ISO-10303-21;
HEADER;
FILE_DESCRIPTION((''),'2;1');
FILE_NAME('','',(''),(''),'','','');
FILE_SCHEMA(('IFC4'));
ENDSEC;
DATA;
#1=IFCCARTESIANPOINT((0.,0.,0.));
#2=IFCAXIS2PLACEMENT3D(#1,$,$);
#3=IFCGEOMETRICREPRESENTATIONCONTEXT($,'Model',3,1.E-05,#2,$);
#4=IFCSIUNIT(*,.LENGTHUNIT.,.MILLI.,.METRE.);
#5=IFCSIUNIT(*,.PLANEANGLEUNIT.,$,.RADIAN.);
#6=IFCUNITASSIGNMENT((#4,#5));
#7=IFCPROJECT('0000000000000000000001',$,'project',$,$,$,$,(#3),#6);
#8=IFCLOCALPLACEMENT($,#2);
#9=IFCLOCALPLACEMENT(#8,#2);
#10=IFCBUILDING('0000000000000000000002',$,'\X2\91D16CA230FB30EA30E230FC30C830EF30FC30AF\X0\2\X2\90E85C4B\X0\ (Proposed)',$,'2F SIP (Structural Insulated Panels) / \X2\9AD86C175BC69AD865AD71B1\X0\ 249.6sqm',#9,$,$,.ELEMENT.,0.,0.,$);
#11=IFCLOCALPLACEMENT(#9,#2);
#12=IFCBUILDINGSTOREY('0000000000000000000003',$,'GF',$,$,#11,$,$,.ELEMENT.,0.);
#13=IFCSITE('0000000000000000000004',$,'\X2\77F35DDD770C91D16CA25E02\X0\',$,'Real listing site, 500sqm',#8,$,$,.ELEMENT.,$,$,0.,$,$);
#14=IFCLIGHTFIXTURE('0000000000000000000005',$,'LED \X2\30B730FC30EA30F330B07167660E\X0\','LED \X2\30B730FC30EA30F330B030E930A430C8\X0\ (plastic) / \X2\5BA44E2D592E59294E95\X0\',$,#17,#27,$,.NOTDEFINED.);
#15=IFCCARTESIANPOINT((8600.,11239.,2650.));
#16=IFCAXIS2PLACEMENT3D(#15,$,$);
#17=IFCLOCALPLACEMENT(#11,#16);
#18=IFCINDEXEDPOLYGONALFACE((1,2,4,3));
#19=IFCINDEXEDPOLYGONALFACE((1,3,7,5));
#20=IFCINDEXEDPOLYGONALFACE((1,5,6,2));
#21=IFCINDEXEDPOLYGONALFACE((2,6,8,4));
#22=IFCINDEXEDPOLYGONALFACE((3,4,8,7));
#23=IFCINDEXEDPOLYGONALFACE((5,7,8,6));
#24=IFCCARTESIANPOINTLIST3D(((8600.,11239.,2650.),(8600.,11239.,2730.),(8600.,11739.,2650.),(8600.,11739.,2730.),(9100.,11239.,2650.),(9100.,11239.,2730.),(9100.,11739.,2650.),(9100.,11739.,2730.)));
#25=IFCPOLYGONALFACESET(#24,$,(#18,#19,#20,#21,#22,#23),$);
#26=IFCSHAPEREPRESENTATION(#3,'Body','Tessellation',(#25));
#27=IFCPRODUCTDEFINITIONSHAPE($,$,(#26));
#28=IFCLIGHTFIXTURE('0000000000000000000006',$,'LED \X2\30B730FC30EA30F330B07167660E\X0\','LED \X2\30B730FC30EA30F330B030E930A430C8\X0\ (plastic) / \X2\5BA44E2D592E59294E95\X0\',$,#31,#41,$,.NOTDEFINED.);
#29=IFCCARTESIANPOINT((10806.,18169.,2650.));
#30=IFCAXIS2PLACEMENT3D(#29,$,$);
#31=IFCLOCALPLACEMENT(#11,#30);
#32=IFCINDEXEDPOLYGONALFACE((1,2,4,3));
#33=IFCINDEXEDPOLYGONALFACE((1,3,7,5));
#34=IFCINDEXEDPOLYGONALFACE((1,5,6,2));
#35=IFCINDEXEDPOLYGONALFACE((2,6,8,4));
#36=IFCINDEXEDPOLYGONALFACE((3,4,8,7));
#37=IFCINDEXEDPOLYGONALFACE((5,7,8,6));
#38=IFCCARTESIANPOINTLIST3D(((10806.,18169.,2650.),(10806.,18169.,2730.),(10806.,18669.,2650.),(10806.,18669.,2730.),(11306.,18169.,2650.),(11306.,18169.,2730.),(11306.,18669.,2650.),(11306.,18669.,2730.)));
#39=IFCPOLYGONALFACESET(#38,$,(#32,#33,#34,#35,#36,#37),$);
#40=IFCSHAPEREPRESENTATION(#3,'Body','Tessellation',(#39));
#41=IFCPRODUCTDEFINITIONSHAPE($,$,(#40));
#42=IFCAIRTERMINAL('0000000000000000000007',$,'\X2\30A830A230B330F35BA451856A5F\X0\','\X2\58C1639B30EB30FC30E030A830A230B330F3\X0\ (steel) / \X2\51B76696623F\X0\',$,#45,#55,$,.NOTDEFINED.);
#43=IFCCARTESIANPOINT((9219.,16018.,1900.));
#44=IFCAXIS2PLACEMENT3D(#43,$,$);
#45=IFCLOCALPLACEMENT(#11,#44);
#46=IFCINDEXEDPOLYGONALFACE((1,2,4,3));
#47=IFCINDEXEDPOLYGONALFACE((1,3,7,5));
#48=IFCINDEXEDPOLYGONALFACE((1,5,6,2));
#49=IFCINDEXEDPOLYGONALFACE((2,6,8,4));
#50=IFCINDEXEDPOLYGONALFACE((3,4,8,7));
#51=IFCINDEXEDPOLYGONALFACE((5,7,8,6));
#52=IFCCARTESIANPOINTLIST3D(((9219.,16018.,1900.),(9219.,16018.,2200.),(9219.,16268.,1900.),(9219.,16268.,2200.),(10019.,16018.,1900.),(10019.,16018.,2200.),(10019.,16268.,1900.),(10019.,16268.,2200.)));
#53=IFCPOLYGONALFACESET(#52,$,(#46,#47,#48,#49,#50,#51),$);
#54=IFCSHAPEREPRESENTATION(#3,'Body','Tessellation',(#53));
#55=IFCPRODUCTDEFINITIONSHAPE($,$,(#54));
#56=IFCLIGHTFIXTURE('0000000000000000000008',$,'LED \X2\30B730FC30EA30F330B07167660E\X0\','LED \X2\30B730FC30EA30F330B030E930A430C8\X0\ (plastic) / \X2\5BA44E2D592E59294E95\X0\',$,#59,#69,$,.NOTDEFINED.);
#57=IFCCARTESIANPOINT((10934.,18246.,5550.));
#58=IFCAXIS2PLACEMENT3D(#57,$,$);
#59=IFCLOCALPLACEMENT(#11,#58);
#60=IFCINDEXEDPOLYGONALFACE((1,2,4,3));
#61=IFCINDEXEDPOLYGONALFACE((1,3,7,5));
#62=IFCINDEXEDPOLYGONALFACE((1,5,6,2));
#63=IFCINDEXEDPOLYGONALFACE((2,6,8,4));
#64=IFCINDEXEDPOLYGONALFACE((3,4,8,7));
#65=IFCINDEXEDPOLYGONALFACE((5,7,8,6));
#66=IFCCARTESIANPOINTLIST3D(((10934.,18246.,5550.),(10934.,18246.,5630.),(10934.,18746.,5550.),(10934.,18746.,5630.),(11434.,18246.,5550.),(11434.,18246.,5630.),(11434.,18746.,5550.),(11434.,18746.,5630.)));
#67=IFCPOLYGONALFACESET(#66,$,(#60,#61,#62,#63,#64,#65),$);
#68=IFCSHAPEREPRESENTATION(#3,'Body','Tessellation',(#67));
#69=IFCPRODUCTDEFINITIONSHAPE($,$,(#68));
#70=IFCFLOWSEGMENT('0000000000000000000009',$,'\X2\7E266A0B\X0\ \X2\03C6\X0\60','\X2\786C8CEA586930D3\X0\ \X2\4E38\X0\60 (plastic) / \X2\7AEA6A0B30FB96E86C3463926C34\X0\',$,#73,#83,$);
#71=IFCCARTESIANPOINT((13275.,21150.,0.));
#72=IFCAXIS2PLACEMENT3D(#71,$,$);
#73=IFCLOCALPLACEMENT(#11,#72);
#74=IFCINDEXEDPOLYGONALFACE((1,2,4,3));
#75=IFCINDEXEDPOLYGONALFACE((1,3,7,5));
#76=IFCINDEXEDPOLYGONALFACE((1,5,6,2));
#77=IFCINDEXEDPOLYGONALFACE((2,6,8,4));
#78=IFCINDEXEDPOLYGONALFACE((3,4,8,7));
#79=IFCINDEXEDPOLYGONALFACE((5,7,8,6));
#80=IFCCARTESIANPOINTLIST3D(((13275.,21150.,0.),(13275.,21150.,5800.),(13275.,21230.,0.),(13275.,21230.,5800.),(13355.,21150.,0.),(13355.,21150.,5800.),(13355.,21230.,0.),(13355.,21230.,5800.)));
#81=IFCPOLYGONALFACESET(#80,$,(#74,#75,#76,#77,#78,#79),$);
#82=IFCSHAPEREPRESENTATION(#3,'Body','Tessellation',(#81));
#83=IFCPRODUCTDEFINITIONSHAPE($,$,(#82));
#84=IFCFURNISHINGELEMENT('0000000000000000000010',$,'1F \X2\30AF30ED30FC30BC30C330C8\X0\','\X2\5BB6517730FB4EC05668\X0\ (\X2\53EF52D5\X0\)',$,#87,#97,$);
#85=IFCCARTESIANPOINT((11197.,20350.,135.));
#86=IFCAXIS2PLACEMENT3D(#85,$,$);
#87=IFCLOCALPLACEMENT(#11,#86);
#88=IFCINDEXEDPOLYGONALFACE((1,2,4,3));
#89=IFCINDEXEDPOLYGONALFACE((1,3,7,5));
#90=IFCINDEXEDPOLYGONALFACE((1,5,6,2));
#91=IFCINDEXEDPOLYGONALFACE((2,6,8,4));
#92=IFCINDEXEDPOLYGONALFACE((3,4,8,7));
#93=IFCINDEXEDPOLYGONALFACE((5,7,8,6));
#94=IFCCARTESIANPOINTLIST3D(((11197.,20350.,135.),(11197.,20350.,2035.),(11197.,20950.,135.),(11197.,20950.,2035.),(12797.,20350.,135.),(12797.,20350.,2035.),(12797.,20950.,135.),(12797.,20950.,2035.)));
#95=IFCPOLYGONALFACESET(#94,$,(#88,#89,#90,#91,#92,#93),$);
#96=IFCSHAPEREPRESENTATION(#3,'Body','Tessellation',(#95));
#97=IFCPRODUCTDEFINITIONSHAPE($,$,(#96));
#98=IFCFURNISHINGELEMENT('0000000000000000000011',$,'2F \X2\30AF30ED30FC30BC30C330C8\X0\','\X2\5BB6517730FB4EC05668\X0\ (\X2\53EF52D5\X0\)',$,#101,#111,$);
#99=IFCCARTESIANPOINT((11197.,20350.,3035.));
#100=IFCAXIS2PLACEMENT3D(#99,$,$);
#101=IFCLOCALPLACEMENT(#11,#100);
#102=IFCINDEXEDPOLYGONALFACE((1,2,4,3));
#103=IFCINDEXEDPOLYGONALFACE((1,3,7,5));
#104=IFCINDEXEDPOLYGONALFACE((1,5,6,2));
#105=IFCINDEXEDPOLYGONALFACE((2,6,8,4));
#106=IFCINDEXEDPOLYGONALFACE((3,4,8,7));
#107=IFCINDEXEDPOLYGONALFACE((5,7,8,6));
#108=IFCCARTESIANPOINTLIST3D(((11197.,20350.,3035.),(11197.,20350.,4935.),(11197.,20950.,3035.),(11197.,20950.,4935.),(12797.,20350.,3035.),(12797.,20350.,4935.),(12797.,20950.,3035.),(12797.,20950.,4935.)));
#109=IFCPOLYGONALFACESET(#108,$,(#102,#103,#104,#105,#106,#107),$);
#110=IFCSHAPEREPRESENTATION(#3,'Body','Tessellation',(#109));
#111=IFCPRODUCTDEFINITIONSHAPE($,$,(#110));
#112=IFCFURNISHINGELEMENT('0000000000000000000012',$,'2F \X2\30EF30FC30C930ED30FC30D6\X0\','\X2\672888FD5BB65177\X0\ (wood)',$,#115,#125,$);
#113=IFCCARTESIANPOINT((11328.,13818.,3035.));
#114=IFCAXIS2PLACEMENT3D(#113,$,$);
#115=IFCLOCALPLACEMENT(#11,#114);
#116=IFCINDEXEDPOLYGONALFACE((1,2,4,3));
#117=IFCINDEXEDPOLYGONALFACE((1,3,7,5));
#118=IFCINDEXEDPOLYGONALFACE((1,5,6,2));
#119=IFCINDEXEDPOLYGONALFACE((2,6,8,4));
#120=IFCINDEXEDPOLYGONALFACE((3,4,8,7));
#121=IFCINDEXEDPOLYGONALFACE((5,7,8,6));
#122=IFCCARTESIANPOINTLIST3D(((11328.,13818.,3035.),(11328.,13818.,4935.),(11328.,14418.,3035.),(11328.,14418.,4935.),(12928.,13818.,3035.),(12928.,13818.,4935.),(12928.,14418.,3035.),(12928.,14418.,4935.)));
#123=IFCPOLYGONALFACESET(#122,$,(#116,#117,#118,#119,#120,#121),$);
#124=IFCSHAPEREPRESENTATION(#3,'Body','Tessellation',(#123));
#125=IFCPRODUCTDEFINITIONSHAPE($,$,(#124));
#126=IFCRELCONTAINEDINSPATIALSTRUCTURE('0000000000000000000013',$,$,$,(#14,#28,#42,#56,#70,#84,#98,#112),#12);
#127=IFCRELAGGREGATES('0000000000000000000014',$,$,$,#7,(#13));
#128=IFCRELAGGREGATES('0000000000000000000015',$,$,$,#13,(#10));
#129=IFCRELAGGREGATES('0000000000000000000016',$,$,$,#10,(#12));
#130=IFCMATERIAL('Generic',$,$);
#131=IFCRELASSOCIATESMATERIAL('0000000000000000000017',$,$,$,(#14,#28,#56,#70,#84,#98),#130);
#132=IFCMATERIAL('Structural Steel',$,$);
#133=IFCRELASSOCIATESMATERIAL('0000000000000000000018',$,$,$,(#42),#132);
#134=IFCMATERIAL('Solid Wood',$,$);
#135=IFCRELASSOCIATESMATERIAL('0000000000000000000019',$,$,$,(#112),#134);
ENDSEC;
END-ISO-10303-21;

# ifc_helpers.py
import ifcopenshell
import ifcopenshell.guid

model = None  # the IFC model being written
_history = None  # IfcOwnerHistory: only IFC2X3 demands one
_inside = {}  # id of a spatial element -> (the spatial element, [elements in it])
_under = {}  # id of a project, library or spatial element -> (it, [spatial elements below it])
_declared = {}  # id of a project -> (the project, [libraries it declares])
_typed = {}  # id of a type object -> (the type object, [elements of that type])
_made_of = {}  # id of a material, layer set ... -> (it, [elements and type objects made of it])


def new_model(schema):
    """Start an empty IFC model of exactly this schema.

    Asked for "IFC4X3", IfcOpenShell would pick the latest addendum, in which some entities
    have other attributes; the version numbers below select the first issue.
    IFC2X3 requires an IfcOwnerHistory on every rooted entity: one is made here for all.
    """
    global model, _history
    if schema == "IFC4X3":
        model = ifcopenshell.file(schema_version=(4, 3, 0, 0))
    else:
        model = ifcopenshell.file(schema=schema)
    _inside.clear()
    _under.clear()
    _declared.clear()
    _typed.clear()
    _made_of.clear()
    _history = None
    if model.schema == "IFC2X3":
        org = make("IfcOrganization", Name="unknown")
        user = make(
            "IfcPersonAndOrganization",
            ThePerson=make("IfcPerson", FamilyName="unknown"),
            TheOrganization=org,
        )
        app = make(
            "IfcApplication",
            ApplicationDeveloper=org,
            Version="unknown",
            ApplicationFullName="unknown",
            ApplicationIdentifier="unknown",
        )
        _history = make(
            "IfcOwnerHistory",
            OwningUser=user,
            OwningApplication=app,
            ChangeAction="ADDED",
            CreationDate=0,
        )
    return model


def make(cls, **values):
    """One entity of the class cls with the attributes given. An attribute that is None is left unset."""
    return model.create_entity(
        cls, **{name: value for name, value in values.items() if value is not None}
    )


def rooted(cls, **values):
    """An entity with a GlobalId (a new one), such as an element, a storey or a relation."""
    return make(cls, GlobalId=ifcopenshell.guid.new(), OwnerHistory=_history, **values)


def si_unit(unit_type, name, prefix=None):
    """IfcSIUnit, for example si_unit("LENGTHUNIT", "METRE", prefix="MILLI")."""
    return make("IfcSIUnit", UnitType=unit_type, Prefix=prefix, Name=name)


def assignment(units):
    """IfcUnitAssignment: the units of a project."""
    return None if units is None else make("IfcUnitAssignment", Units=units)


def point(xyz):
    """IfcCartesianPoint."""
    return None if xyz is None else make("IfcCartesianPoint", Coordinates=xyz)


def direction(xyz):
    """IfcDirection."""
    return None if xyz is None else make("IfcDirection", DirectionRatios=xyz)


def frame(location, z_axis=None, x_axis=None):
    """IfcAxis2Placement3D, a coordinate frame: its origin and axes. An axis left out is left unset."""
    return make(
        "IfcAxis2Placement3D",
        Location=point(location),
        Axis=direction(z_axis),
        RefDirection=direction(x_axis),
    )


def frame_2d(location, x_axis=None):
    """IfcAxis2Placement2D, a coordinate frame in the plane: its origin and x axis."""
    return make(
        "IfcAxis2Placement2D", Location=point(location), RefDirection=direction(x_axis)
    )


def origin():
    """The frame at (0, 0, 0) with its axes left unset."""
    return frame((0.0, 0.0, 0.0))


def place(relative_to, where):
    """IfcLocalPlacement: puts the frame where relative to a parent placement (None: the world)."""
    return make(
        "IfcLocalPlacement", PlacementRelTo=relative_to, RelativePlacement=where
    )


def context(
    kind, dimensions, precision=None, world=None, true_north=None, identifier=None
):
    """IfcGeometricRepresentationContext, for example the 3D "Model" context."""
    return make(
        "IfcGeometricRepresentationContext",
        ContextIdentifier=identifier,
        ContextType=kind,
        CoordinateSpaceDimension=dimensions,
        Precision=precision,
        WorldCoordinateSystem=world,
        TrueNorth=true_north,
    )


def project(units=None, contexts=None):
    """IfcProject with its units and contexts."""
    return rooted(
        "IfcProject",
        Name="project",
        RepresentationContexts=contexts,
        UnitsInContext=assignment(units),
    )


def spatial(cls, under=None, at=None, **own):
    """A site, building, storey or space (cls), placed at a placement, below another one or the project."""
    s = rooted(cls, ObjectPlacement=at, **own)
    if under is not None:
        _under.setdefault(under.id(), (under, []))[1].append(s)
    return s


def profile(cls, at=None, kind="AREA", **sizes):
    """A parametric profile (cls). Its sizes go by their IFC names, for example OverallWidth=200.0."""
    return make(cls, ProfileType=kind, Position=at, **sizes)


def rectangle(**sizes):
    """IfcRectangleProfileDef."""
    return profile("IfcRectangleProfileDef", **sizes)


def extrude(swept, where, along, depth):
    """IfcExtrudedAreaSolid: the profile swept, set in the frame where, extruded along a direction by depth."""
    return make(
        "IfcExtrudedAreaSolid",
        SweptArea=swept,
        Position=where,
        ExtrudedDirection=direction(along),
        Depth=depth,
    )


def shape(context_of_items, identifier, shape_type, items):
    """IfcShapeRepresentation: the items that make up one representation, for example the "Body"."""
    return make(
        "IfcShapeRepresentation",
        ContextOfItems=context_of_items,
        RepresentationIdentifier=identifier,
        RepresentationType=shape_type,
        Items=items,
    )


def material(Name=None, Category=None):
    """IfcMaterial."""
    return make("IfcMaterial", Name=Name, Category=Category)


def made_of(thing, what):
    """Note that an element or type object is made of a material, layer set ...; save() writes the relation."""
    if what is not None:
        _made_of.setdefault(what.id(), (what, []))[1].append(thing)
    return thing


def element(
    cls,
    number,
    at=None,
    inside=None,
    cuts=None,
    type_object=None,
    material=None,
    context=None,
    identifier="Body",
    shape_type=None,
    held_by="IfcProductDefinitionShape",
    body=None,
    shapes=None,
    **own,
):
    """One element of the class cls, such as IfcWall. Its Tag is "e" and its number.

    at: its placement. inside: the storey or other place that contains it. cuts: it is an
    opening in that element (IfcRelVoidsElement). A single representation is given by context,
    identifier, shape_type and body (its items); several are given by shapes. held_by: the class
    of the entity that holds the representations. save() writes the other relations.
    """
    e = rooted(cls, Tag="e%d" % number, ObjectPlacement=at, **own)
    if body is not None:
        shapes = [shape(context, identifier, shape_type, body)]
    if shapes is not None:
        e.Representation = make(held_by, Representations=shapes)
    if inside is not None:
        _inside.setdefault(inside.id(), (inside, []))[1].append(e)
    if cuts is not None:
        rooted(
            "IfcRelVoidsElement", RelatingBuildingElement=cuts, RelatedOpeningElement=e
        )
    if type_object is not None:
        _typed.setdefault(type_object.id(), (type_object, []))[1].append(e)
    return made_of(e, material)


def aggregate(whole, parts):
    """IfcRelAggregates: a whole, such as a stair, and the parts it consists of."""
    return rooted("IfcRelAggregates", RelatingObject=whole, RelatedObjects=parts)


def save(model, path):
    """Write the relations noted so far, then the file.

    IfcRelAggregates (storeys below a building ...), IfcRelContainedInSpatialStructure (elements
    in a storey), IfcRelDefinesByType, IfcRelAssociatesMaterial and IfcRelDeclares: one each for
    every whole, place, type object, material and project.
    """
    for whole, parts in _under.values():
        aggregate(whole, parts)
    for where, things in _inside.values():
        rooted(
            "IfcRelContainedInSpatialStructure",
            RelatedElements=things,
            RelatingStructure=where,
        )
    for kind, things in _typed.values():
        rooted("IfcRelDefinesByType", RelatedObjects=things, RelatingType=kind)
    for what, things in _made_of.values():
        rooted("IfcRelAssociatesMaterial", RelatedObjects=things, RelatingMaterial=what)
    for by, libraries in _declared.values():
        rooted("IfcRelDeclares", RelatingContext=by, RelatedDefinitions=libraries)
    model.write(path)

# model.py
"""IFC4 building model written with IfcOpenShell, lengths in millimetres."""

from ifc_helpers import new_model, si_unit, frame, frame_2d, origin, place, context, project, spatial, rectangle, extrude, material, element, save


model = new_model("IFC4")

# Units and contexts
model_context = context("Model", 3, precision=1e-05, world=origin())
ifc_project = project(units=[si_unit("LENGTHUNIT", "METRE", prefix="MILLI"), si_unit("PLANEANGLEUNIT", "RADIAN")], contexts=[model_context])

# Site, building, storey
site_placement = place(None, origin())
site = spatial("IfcSite", under=ifc_project, at=site_placement, Name="石川県金沢市", ObjectType="Real listing site, 500sqm", CompositionType="ELEMENT", RefElevation=0.0)
building_placement = place(site_placement, origin())
building = spatial("IfcBuilding", under=site, at=building_placement, Name="金沢・リモートワーク2部屋 (Proposed)", ObjectType="2F SIP (Structural Insulated Panels) / 高気密高断熱 249.6sqm", CompositionType="ELEMENT", ElevationOfRefHeight=0.0, ElevationOfTerrain=0.0)
storey_placement = place(building_placement, origin())
storey = spatial("IfcBuildingStorey", under=building, at=storey_placement, Name="GF", CompositionType="ELEMENT", Elevation=0.0)

# Shared definitions
ifc_material_1 = material(Name="Solid Wood")
ifc_material_2 = material(Name="Structural Steel")

# Shared definitions
ifc_material_3 = material(Name="Generic")

# Light fixtures
light_fixture_1_placement = place(storey_placement, frame((8600.0, 11239.0, 2650.0)))
element("IfcLightFixture", 1, at=light_fixture_1_placement, inside=storey, material=ifc_material_3, Name="LED シーリング照明", Description="LED シーリングライト (plastic) / 室中央天井", PredefinedType="NOTDEFINED", context=model_context, shape_type="SweptSolid", body=[
    extrude(rectangle(XDim=500.0, YDim=500.0, at=frame_2d((250.0, 250.0))), frame((8600.0, 11239.0, 2650.0)), (0.0, 0.0, 1.0), 80.0),
])
light_fixture_2_placement = place(storey_placement, frame((10806.0, 18169.0, 2650.0)))
element("IfcLightFixture", 2, at=light_fixture_2_placement, inside=storey, material=ifc_material_3, Name="LED シーリング照明", Description="LED シーリングライト (plastic) / 室中央天井", PredefinedType="NOTDEFINED", context=model_context, shape_type="SweptSolid", body=[
    extrude(rectangle(XDim=500.0, YDim=500.0, at=frame_2d((250.0, 250.0))), frame((10806.0, 18169.0, 2650.0)), (0.0, 0.0, 1.0), 80.0),
])

# Air terminal
air_terminal_placement = place(storey_placement, frame((9219.0, 16018.0, 1900.0)))
element("IfcAirTerminal", 3, at=air_terminal_placement, inside=storey, material=ifc_material_2, Name="エアコン室内機", Description="壁掛ルームエアコン (steel) / 冷暖房", PredefinedType="NOTDEFINED", context=model_context, shape_type="SweptSolid", body=[
    extrude(rectangle(XDim=800.0, YDim=250.0, at=frame_2d((400.0, 125.0))), frame((9219.0, 16018.0, 1900.0)), (0.0, 0.0, 1.0), 300.0),
])

# Light fixture
light_fixture_3_placement = place(storey_placement, frame((10934.0, 18246.0, 5550.0)))
element("IfcLightFixture", 4, at=light_fixture_3_placement, inside=storey, material=ifc_material_3, Name="LED シーリング照明", Description="LED シーリングライト (plastic) / 室中央天井", PredefinedType="NOTDEFINED", context=model_context, shape_type="SweptSolid", body=[
    extrude(rectangle(XDim=500.0, YDim=500.0, at=frame_2d((250.0, 250.0))), frame((10934.0, 18246.0, 5550.0)), (0.0, 0.0, 1.0), 80.0),
])

# Flow segment
flow_segment_placement = place(storey_placement, frame((13275.0, 21150.0, 0.0)))
element("IfcFlowSegment", 5, at=flow_segment_placement, inside=storey, material=ifc_material_3, Name="縦樋 φ60", Description="硬質塩ビ 丸60 (plastic) / 竪樋・雨水排水", context=model_context, shape_type="SweptSolid", body=[
    extrude(rectangle(XDim=80.0, YDim=80.0, at=frame_2d((40.0, 40.0))), frame((13275.0, 21150.0, 0.0)), (0.0, 0.0, 1.0), 5800.0),
])

# Furnishing elements
furnishing_1_placement = place(storey_placement, frame((11197.0, 20350.0, 135.0)))
element("IfcFurnishingElement", 6, at=furnishing_1_placement, inside=storey, material=ifc_material_3, Name="1F クローゼット", Description="家具・什器 (可動)", context=model_context, shape_type="SweptSolid", body=[
    extrude(rectangle(XDim=1600.0, YDim=600.0, at=frame_2d((800.0, 300.0))), frame((11197.0, 20350.0, 135.0)), (0.0, 0.0, 1.0), 1900.0),
])
furnishing_2_placement = place(storey_placement, frame((11197.0, 20350.0, 3035.0)))
element("IfcFurnishingElement", 7, at=furnishing_2_placement, inside=storey, material=ifc_material_3, Name="2F クローゼット", Description="家具・什器 (可動)", context=model_context, shape_type="SweptSolid", body=[
    extrude(rectangle(XDim=1600.0, YDim=600.0, at=frame_2d((800.0, 300.0))), frame((11197.0, 20350.0, 3035.0)), (0.0, 0.0, 1.0), 1900.0),
])
furnishing_3_placement = place(storey_placement, frame((11328.0, 13818.0, 3035.0)))
element("IfcFurnishingElement", 8, at=furnishing_3_placement, inside=storey, material=ifc_material_1, Name="2F ワードローブ", Description="木製家具 (wood)", context=model_context, shape_type="SweptSolid", body=[
    extrude(rectangle(XDim=1600.0, YDim=600.0, at=frame_2d((800.0, 300.0))), frame((11328.0, 13818.0, 3035.0)), (0.0, 0.0, 1.0), 1900.0),
])

save(model, "model.ifc")
